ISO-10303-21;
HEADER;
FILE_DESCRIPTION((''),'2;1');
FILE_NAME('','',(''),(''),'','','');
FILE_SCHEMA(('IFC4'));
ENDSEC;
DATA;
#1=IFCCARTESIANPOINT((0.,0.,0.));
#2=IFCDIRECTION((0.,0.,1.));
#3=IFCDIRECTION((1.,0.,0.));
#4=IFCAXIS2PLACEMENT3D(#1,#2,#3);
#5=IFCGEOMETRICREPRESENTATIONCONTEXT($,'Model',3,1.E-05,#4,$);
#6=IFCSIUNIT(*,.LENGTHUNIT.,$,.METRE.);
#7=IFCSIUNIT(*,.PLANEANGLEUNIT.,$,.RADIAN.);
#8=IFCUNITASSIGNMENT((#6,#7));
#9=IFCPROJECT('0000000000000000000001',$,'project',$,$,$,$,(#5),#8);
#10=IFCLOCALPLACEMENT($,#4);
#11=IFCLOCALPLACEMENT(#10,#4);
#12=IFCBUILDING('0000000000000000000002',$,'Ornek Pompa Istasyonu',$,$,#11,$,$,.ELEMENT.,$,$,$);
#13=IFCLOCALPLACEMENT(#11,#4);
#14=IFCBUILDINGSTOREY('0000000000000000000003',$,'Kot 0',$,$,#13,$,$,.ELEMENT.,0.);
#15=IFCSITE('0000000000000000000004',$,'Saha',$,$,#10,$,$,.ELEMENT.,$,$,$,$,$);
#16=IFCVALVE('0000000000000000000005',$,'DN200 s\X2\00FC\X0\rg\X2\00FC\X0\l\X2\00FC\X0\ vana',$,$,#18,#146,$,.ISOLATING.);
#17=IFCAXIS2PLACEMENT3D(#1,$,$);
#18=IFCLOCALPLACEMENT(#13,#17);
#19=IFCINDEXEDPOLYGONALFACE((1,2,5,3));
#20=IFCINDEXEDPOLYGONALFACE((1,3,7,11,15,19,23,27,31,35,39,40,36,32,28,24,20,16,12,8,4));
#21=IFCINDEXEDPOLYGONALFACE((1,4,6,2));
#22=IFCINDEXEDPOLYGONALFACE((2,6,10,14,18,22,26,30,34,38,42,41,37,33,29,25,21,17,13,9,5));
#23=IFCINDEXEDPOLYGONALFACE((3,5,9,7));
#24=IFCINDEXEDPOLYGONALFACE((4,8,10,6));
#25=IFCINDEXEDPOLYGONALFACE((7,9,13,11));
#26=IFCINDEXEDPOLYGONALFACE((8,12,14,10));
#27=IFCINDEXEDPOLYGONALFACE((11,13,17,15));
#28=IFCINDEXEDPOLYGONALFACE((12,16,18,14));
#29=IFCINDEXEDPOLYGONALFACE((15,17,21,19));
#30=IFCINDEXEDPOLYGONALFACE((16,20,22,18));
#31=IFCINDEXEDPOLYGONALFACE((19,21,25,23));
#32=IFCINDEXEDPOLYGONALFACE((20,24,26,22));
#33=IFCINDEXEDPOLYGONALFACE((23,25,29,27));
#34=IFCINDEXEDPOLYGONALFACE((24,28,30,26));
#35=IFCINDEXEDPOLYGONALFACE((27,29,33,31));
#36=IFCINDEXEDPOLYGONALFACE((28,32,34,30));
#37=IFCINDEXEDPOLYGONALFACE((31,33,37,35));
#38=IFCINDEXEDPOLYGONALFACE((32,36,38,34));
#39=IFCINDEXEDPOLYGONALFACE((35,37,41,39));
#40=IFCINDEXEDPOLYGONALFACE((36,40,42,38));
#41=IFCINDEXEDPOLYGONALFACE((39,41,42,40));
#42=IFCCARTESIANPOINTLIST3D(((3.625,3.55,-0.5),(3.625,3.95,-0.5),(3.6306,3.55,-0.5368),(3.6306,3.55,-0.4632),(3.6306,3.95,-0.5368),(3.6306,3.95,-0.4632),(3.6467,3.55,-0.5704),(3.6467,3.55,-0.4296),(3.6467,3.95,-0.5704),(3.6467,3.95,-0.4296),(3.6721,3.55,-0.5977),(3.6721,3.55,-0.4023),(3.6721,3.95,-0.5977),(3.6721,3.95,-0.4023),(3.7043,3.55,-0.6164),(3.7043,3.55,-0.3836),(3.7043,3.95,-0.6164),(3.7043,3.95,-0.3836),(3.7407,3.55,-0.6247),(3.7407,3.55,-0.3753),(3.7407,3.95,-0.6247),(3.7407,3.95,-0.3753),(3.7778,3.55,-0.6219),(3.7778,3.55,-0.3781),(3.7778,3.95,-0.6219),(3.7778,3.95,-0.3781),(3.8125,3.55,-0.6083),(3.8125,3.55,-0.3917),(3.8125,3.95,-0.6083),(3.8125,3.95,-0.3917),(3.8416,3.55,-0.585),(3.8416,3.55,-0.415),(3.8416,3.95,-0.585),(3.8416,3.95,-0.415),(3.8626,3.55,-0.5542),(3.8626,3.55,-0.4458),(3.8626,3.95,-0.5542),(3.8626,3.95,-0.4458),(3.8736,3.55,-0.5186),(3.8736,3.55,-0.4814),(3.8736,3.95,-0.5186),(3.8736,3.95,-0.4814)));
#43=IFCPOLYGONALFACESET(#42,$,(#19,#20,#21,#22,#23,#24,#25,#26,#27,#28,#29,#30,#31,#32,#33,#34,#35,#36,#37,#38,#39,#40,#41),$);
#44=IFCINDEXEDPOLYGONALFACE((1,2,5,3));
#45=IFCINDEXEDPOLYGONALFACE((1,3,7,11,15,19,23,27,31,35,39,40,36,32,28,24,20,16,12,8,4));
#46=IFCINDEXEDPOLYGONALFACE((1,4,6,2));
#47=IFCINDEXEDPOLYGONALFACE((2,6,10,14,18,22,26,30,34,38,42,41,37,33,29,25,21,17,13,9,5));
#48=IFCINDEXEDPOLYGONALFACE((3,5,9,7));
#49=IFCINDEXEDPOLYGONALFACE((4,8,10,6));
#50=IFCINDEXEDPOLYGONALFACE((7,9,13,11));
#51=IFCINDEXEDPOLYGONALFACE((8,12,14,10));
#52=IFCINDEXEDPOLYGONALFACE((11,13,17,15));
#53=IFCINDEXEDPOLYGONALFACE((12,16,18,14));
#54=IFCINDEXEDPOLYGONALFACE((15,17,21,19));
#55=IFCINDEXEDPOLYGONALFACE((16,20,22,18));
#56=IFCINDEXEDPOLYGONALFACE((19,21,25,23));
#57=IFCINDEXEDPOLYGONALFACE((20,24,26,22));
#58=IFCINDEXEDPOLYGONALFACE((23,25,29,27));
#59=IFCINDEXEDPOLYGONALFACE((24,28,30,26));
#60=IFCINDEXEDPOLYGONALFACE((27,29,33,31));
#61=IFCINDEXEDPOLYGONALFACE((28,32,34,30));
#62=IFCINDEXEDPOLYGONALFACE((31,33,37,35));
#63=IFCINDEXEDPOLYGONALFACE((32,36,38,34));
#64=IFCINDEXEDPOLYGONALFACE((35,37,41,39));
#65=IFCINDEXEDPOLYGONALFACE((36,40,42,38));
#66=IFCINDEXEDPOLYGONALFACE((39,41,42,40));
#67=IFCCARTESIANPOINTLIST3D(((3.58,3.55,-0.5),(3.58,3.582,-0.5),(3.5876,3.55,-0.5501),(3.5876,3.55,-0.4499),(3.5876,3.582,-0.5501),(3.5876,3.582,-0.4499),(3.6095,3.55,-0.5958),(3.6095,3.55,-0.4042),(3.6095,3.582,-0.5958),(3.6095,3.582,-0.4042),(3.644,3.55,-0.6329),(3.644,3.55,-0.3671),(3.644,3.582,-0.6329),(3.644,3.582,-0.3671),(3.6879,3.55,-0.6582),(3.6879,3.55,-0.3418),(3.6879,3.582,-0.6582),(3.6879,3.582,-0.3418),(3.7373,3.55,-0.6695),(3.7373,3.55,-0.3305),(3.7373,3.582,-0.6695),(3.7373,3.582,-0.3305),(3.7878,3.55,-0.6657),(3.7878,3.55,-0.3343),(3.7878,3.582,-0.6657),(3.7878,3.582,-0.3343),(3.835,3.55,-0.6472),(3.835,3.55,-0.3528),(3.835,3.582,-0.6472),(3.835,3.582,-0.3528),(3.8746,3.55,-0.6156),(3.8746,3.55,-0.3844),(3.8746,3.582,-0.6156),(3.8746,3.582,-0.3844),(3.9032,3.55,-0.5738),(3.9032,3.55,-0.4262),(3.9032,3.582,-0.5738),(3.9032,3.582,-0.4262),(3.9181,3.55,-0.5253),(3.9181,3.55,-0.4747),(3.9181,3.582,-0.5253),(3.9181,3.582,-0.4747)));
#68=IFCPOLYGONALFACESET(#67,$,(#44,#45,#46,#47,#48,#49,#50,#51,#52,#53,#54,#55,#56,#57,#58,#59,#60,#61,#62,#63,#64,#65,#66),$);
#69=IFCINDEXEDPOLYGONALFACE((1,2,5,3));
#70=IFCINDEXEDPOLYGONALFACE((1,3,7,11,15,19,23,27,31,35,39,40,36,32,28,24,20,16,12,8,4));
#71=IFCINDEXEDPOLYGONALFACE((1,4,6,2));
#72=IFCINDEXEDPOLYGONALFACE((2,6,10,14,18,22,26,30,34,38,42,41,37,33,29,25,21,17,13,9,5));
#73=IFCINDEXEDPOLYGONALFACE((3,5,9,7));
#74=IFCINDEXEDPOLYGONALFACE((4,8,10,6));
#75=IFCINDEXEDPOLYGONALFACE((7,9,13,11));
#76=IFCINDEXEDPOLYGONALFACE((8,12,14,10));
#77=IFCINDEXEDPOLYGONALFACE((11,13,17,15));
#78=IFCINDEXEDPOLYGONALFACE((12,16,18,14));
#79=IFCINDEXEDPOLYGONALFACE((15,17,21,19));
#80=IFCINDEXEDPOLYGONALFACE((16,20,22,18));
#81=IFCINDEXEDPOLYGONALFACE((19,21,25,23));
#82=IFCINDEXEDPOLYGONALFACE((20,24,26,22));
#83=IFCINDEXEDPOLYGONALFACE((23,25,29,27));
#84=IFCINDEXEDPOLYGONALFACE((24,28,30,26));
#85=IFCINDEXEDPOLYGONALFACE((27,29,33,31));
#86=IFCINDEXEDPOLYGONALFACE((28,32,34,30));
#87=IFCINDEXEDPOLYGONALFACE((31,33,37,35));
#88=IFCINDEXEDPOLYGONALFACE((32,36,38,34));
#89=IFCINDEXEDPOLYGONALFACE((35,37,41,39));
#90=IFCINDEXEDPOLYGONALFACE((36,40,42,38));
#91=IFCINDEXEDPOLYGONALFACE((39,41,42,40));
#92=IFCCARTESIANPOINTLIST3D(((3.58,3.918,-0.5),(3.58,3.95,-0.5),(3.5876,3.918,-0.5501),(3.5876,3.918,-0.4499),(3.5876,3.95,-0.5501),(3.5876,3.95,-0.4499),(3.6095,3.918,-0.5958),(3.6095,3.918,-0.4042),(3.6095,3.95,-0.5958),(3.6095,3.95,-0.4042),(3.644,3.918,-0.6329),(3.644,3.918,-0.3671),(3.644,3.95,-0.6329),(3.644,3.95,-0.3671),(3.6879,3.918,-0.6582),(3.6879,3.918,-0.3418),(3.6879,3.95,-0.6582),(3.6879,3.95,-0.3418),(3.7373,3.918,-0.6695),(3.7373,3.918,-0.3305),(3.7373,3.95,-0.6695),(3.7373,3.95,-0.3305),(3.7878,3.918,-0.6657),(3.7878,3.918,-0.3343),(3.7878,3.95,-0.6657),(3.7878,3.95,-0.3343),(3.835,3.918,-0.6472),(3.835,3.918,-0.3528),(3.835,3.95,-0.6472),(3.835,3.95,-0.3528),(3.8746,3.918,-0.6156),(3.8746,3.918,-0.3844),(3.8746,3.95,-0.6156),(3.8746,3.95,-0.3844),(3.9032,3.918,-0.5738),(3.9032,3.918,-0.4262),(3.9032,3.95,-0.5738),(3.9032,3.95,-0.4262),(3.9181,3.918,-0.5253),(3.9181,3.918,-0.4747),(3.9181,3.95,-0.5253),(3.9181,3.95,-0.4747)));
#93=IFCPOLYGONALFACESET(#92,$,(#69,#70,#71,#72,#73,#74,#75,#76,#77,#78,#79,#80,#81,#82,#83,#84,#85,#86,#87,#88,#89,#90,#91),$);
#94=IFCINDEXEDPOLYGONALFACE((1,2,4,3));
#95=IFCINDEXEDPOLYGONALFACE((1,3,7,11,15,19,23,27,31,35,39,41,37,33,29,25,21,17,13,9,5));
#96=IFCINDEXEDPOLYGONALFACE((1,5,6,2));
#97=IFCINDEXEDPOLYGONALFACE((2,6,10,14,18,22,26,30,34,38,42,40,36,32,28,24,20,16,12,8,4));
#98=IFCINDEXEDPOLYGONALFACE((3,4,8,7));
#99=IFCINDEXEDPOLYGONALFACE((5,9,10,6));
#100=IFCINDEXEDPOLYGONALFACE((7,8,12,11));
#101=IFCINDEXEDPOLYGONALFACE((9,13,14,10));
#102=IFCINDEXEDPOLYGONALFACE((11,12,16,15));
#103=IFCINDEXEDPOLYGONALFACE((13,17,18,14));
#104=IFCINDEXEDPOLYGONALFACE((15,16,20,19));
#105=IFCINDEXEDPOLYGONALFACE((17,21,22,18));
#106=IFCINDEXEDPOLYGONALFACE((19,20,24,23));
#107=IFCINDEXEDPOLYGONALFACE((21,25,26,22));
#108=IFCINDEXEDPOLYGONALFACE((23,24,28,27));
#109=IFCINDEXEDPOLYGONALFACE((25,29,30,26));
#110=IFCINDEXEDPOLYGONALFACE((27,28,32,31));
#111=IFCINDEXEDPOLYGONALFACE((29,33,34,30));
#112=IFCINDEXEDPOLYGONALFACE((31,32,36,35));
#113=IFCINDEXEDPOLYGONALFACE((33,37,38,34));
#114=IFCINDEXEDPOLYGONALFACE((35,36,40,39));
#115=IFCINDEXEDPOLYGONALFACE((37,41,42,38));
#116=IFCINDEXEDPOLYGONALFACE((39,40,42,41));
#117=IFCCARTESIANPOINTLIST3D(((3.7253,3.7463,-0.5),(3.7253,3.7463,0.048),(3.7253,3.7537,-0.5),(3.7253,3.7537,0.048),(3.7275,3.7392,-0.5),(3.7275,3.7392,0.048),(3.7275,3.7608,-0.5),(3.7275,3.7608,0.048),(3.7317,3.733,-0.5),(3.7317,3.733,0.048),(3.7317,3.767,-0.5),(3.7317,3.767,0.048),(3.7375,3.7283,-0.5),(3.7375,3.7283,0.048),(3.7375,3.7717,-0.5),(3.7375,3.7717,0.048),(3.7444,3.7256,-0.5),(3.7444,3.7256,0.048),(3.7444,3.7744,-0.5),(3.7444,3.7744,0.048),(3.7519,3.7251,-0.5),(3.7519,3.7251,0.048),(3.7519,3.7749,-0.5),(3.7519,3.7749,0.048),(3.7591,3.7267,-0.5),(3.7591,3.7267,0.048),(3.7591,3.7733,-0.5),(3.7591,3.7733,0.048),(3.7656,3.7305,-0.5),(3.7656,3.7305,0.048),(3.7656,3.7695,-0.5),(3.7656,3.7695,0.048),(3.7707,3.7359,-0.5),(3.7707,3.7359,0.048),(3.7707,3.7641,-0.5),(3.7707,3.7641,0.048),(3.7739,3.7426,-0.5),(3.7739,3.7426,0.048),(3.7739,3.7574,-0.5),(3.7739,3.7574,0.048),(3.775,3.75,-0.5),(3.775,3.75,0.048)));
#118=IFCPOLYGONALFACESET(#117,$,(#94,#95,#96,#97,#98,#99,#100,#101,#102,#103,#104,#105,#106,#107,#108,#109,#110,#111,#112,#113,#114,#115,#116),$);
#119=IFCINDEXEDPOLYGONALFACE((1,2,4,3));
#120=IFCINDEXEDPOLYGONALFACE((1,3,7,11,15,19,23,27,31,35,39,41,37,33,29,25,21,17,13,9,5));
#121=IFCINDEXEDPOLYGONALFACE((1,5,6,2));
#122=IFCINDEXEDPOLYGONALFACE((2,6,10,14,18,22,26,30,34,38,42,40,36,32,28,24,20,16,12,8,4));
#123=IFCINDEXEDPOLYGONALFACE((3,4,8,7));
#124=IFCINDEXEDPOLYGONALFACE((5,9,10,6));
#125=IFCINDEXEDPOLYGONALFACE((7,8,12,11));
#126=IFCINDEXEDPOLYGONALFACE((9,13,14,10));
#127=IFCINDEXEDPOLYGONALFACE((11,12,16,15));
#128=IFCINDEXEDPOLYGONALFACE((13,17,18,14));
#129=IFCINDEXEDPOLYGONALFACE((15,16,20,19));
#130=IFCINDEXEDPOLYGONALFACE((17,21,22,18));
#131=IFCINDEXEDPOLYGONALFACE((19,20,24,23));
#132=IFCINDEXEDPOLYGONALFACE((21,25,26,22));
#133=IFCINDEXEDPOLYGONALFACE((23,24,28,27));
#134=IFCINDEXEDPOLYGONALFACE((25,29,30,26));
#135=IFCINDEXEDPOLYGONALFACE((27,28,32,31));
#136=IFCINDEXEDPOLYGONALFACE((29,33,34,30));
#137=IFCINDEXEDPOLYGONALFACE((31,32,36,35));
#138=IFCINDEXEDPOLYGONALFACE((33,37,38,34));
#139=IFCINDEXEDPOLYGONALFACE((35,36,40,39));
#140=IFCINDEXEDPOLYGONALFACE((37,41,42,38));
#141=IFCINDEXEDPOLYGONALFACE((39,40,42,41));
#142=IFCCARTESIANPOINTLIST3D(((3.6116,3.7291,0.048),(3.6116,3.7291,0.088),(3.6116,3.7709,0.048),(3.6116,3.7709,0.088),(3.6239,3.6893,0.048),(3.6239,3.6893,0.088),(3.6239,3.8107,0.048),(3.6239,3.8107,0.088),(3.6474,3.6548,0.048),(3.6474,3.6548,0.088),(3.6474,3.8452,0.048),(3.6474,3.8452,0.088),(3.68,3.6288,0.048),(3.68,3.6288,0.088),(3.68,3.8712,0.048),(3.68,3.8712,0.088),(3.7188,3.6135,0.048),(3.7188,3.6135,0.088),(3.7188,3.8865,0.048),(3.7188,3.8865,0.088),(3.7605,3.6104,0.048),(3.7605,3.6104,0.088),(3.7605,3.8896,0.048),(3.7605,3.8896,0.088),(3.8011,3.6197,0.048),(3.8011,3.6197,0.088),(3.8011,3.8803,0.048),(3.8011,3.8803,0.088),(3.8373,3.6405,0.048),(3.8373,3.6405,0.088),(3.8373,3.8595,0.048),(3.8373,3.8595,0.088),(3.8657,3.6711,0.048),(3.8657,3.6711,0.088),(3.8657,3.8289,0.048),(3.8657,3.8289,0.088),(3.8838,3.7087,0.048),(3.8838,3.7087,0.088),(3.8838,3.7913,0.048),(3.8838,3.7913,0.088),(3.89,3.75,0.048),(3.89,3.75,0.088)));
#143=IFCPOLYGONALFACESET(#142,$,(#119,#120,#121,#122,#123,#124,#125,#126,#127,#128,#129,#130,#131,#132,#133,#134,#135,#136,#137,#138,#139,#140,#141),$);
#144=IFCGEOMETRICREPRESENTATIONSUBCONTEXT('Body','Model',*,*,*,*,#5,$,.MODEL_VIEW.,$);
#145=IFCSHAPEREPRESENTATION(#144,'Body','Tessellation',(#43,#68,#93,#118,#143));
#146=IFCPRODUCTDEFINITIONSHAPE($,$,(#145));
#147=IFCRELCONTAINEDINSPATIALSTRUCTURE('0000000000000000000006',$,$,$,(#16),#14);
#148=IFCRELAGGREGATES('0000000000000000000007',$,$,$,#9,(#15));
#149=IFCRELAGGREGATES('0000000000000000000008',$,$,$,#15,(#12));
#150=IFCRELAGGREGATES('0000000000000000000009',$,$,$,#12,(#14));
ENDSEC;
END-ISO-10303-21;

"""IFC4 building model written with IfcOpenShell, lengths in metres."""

from ifc_helpers import new_model, si_unit, frame, origin_with_axes, origin_2d, place, context, subcontext, project, spatial, circle, extrude, element, save


model = new_model("IFC4")

# Units and contexts
model_context = context("Model", 3, precision=1e-05, world=origin_with_axes())
body_context = subcontext(model_context, "Body", "Model", "MODEL_VIEW")
ifc_project = project(units=[si_unit("LENGTHUNIT", "METRE"), si_unit("PLANEANGLEUNIT", "RADIAN")], contexts=[model_context])

# Site, building, storey
site_placement = place(None, origin_with_axes())
site = spatial("IfcSite", under=ifc_project, at=site_placement, Name="Saha", CompositionType="ELEMENT")
building_placement = place(site_placement, origin_with_axes())
building = spatial("IfcBuilding", under=site, at=building_placement, Name="Ornek Pompa Istasyonu", CompositionType="ELEMENT")
storey_placement = place(building_placement, origin_with_axes())
storey = spatial("IfcBuildingStorey", under=building, at=storey_placement, Name="Kot 0", CompositionType="ELEMENT", Elevation=0.0)

# Valve
valve_1_placement = place(storey_placement, origin_with_axes())
element("IfcValve", 1, at=valve_1_placement, inside=storey, Name="DN200 sürgülü vana", PredefinedType="ISOLATING", context=body_context, shape_type="SweptSolid", body=[
    extrude(circle(Radius=0.125, at=origin_2d()), frame((3.75, 3.55, -0.5), z_axis=(0.0, 1.0, 0.0), x_axis=(-1.0, 0.0, 0.0)), (0.0, 0.0, 1.0), 0.4),
    extrude(circle(Radius=0.17, at=origin_2d()), frame((3.75, 3.55, -0.5), z_axis=(0.0, 1.0, 0.0), x_axis=(-1.0, 0.0, 0.0)), (0.0, 0.0, 1.0), 0.032),
    extrude(circle(Radius=0.17, at=origin_2d()), frame((3.75, 3.918, -0.5), z_axis=(0.0, 1.0, 0.0), x_axis=(-1.0, 0.0, 0.0)), (0.0, 0.0, 1.0), 0.032),
    extrude(circle(Radius=0.025, at=origin_2d()), frame((3.75, 3.75, -0.5), z_axis=(0.0, 0.0, 1.0), x_axis=(1.0, 0.0, 0.0)), (0.0, 0.0, 1.0), 0.548),
    extrude(circle(Radius=0.14, at=origin_2d()), frame((3.75, 3.75, 0.048), z_axis=(0.0, 0.0, 1.0), x_axis=(1.0, 0.0, 0.0)), (0.0, 0.0, 1.0), 0.04),
])

save(model, "model.ifc")
